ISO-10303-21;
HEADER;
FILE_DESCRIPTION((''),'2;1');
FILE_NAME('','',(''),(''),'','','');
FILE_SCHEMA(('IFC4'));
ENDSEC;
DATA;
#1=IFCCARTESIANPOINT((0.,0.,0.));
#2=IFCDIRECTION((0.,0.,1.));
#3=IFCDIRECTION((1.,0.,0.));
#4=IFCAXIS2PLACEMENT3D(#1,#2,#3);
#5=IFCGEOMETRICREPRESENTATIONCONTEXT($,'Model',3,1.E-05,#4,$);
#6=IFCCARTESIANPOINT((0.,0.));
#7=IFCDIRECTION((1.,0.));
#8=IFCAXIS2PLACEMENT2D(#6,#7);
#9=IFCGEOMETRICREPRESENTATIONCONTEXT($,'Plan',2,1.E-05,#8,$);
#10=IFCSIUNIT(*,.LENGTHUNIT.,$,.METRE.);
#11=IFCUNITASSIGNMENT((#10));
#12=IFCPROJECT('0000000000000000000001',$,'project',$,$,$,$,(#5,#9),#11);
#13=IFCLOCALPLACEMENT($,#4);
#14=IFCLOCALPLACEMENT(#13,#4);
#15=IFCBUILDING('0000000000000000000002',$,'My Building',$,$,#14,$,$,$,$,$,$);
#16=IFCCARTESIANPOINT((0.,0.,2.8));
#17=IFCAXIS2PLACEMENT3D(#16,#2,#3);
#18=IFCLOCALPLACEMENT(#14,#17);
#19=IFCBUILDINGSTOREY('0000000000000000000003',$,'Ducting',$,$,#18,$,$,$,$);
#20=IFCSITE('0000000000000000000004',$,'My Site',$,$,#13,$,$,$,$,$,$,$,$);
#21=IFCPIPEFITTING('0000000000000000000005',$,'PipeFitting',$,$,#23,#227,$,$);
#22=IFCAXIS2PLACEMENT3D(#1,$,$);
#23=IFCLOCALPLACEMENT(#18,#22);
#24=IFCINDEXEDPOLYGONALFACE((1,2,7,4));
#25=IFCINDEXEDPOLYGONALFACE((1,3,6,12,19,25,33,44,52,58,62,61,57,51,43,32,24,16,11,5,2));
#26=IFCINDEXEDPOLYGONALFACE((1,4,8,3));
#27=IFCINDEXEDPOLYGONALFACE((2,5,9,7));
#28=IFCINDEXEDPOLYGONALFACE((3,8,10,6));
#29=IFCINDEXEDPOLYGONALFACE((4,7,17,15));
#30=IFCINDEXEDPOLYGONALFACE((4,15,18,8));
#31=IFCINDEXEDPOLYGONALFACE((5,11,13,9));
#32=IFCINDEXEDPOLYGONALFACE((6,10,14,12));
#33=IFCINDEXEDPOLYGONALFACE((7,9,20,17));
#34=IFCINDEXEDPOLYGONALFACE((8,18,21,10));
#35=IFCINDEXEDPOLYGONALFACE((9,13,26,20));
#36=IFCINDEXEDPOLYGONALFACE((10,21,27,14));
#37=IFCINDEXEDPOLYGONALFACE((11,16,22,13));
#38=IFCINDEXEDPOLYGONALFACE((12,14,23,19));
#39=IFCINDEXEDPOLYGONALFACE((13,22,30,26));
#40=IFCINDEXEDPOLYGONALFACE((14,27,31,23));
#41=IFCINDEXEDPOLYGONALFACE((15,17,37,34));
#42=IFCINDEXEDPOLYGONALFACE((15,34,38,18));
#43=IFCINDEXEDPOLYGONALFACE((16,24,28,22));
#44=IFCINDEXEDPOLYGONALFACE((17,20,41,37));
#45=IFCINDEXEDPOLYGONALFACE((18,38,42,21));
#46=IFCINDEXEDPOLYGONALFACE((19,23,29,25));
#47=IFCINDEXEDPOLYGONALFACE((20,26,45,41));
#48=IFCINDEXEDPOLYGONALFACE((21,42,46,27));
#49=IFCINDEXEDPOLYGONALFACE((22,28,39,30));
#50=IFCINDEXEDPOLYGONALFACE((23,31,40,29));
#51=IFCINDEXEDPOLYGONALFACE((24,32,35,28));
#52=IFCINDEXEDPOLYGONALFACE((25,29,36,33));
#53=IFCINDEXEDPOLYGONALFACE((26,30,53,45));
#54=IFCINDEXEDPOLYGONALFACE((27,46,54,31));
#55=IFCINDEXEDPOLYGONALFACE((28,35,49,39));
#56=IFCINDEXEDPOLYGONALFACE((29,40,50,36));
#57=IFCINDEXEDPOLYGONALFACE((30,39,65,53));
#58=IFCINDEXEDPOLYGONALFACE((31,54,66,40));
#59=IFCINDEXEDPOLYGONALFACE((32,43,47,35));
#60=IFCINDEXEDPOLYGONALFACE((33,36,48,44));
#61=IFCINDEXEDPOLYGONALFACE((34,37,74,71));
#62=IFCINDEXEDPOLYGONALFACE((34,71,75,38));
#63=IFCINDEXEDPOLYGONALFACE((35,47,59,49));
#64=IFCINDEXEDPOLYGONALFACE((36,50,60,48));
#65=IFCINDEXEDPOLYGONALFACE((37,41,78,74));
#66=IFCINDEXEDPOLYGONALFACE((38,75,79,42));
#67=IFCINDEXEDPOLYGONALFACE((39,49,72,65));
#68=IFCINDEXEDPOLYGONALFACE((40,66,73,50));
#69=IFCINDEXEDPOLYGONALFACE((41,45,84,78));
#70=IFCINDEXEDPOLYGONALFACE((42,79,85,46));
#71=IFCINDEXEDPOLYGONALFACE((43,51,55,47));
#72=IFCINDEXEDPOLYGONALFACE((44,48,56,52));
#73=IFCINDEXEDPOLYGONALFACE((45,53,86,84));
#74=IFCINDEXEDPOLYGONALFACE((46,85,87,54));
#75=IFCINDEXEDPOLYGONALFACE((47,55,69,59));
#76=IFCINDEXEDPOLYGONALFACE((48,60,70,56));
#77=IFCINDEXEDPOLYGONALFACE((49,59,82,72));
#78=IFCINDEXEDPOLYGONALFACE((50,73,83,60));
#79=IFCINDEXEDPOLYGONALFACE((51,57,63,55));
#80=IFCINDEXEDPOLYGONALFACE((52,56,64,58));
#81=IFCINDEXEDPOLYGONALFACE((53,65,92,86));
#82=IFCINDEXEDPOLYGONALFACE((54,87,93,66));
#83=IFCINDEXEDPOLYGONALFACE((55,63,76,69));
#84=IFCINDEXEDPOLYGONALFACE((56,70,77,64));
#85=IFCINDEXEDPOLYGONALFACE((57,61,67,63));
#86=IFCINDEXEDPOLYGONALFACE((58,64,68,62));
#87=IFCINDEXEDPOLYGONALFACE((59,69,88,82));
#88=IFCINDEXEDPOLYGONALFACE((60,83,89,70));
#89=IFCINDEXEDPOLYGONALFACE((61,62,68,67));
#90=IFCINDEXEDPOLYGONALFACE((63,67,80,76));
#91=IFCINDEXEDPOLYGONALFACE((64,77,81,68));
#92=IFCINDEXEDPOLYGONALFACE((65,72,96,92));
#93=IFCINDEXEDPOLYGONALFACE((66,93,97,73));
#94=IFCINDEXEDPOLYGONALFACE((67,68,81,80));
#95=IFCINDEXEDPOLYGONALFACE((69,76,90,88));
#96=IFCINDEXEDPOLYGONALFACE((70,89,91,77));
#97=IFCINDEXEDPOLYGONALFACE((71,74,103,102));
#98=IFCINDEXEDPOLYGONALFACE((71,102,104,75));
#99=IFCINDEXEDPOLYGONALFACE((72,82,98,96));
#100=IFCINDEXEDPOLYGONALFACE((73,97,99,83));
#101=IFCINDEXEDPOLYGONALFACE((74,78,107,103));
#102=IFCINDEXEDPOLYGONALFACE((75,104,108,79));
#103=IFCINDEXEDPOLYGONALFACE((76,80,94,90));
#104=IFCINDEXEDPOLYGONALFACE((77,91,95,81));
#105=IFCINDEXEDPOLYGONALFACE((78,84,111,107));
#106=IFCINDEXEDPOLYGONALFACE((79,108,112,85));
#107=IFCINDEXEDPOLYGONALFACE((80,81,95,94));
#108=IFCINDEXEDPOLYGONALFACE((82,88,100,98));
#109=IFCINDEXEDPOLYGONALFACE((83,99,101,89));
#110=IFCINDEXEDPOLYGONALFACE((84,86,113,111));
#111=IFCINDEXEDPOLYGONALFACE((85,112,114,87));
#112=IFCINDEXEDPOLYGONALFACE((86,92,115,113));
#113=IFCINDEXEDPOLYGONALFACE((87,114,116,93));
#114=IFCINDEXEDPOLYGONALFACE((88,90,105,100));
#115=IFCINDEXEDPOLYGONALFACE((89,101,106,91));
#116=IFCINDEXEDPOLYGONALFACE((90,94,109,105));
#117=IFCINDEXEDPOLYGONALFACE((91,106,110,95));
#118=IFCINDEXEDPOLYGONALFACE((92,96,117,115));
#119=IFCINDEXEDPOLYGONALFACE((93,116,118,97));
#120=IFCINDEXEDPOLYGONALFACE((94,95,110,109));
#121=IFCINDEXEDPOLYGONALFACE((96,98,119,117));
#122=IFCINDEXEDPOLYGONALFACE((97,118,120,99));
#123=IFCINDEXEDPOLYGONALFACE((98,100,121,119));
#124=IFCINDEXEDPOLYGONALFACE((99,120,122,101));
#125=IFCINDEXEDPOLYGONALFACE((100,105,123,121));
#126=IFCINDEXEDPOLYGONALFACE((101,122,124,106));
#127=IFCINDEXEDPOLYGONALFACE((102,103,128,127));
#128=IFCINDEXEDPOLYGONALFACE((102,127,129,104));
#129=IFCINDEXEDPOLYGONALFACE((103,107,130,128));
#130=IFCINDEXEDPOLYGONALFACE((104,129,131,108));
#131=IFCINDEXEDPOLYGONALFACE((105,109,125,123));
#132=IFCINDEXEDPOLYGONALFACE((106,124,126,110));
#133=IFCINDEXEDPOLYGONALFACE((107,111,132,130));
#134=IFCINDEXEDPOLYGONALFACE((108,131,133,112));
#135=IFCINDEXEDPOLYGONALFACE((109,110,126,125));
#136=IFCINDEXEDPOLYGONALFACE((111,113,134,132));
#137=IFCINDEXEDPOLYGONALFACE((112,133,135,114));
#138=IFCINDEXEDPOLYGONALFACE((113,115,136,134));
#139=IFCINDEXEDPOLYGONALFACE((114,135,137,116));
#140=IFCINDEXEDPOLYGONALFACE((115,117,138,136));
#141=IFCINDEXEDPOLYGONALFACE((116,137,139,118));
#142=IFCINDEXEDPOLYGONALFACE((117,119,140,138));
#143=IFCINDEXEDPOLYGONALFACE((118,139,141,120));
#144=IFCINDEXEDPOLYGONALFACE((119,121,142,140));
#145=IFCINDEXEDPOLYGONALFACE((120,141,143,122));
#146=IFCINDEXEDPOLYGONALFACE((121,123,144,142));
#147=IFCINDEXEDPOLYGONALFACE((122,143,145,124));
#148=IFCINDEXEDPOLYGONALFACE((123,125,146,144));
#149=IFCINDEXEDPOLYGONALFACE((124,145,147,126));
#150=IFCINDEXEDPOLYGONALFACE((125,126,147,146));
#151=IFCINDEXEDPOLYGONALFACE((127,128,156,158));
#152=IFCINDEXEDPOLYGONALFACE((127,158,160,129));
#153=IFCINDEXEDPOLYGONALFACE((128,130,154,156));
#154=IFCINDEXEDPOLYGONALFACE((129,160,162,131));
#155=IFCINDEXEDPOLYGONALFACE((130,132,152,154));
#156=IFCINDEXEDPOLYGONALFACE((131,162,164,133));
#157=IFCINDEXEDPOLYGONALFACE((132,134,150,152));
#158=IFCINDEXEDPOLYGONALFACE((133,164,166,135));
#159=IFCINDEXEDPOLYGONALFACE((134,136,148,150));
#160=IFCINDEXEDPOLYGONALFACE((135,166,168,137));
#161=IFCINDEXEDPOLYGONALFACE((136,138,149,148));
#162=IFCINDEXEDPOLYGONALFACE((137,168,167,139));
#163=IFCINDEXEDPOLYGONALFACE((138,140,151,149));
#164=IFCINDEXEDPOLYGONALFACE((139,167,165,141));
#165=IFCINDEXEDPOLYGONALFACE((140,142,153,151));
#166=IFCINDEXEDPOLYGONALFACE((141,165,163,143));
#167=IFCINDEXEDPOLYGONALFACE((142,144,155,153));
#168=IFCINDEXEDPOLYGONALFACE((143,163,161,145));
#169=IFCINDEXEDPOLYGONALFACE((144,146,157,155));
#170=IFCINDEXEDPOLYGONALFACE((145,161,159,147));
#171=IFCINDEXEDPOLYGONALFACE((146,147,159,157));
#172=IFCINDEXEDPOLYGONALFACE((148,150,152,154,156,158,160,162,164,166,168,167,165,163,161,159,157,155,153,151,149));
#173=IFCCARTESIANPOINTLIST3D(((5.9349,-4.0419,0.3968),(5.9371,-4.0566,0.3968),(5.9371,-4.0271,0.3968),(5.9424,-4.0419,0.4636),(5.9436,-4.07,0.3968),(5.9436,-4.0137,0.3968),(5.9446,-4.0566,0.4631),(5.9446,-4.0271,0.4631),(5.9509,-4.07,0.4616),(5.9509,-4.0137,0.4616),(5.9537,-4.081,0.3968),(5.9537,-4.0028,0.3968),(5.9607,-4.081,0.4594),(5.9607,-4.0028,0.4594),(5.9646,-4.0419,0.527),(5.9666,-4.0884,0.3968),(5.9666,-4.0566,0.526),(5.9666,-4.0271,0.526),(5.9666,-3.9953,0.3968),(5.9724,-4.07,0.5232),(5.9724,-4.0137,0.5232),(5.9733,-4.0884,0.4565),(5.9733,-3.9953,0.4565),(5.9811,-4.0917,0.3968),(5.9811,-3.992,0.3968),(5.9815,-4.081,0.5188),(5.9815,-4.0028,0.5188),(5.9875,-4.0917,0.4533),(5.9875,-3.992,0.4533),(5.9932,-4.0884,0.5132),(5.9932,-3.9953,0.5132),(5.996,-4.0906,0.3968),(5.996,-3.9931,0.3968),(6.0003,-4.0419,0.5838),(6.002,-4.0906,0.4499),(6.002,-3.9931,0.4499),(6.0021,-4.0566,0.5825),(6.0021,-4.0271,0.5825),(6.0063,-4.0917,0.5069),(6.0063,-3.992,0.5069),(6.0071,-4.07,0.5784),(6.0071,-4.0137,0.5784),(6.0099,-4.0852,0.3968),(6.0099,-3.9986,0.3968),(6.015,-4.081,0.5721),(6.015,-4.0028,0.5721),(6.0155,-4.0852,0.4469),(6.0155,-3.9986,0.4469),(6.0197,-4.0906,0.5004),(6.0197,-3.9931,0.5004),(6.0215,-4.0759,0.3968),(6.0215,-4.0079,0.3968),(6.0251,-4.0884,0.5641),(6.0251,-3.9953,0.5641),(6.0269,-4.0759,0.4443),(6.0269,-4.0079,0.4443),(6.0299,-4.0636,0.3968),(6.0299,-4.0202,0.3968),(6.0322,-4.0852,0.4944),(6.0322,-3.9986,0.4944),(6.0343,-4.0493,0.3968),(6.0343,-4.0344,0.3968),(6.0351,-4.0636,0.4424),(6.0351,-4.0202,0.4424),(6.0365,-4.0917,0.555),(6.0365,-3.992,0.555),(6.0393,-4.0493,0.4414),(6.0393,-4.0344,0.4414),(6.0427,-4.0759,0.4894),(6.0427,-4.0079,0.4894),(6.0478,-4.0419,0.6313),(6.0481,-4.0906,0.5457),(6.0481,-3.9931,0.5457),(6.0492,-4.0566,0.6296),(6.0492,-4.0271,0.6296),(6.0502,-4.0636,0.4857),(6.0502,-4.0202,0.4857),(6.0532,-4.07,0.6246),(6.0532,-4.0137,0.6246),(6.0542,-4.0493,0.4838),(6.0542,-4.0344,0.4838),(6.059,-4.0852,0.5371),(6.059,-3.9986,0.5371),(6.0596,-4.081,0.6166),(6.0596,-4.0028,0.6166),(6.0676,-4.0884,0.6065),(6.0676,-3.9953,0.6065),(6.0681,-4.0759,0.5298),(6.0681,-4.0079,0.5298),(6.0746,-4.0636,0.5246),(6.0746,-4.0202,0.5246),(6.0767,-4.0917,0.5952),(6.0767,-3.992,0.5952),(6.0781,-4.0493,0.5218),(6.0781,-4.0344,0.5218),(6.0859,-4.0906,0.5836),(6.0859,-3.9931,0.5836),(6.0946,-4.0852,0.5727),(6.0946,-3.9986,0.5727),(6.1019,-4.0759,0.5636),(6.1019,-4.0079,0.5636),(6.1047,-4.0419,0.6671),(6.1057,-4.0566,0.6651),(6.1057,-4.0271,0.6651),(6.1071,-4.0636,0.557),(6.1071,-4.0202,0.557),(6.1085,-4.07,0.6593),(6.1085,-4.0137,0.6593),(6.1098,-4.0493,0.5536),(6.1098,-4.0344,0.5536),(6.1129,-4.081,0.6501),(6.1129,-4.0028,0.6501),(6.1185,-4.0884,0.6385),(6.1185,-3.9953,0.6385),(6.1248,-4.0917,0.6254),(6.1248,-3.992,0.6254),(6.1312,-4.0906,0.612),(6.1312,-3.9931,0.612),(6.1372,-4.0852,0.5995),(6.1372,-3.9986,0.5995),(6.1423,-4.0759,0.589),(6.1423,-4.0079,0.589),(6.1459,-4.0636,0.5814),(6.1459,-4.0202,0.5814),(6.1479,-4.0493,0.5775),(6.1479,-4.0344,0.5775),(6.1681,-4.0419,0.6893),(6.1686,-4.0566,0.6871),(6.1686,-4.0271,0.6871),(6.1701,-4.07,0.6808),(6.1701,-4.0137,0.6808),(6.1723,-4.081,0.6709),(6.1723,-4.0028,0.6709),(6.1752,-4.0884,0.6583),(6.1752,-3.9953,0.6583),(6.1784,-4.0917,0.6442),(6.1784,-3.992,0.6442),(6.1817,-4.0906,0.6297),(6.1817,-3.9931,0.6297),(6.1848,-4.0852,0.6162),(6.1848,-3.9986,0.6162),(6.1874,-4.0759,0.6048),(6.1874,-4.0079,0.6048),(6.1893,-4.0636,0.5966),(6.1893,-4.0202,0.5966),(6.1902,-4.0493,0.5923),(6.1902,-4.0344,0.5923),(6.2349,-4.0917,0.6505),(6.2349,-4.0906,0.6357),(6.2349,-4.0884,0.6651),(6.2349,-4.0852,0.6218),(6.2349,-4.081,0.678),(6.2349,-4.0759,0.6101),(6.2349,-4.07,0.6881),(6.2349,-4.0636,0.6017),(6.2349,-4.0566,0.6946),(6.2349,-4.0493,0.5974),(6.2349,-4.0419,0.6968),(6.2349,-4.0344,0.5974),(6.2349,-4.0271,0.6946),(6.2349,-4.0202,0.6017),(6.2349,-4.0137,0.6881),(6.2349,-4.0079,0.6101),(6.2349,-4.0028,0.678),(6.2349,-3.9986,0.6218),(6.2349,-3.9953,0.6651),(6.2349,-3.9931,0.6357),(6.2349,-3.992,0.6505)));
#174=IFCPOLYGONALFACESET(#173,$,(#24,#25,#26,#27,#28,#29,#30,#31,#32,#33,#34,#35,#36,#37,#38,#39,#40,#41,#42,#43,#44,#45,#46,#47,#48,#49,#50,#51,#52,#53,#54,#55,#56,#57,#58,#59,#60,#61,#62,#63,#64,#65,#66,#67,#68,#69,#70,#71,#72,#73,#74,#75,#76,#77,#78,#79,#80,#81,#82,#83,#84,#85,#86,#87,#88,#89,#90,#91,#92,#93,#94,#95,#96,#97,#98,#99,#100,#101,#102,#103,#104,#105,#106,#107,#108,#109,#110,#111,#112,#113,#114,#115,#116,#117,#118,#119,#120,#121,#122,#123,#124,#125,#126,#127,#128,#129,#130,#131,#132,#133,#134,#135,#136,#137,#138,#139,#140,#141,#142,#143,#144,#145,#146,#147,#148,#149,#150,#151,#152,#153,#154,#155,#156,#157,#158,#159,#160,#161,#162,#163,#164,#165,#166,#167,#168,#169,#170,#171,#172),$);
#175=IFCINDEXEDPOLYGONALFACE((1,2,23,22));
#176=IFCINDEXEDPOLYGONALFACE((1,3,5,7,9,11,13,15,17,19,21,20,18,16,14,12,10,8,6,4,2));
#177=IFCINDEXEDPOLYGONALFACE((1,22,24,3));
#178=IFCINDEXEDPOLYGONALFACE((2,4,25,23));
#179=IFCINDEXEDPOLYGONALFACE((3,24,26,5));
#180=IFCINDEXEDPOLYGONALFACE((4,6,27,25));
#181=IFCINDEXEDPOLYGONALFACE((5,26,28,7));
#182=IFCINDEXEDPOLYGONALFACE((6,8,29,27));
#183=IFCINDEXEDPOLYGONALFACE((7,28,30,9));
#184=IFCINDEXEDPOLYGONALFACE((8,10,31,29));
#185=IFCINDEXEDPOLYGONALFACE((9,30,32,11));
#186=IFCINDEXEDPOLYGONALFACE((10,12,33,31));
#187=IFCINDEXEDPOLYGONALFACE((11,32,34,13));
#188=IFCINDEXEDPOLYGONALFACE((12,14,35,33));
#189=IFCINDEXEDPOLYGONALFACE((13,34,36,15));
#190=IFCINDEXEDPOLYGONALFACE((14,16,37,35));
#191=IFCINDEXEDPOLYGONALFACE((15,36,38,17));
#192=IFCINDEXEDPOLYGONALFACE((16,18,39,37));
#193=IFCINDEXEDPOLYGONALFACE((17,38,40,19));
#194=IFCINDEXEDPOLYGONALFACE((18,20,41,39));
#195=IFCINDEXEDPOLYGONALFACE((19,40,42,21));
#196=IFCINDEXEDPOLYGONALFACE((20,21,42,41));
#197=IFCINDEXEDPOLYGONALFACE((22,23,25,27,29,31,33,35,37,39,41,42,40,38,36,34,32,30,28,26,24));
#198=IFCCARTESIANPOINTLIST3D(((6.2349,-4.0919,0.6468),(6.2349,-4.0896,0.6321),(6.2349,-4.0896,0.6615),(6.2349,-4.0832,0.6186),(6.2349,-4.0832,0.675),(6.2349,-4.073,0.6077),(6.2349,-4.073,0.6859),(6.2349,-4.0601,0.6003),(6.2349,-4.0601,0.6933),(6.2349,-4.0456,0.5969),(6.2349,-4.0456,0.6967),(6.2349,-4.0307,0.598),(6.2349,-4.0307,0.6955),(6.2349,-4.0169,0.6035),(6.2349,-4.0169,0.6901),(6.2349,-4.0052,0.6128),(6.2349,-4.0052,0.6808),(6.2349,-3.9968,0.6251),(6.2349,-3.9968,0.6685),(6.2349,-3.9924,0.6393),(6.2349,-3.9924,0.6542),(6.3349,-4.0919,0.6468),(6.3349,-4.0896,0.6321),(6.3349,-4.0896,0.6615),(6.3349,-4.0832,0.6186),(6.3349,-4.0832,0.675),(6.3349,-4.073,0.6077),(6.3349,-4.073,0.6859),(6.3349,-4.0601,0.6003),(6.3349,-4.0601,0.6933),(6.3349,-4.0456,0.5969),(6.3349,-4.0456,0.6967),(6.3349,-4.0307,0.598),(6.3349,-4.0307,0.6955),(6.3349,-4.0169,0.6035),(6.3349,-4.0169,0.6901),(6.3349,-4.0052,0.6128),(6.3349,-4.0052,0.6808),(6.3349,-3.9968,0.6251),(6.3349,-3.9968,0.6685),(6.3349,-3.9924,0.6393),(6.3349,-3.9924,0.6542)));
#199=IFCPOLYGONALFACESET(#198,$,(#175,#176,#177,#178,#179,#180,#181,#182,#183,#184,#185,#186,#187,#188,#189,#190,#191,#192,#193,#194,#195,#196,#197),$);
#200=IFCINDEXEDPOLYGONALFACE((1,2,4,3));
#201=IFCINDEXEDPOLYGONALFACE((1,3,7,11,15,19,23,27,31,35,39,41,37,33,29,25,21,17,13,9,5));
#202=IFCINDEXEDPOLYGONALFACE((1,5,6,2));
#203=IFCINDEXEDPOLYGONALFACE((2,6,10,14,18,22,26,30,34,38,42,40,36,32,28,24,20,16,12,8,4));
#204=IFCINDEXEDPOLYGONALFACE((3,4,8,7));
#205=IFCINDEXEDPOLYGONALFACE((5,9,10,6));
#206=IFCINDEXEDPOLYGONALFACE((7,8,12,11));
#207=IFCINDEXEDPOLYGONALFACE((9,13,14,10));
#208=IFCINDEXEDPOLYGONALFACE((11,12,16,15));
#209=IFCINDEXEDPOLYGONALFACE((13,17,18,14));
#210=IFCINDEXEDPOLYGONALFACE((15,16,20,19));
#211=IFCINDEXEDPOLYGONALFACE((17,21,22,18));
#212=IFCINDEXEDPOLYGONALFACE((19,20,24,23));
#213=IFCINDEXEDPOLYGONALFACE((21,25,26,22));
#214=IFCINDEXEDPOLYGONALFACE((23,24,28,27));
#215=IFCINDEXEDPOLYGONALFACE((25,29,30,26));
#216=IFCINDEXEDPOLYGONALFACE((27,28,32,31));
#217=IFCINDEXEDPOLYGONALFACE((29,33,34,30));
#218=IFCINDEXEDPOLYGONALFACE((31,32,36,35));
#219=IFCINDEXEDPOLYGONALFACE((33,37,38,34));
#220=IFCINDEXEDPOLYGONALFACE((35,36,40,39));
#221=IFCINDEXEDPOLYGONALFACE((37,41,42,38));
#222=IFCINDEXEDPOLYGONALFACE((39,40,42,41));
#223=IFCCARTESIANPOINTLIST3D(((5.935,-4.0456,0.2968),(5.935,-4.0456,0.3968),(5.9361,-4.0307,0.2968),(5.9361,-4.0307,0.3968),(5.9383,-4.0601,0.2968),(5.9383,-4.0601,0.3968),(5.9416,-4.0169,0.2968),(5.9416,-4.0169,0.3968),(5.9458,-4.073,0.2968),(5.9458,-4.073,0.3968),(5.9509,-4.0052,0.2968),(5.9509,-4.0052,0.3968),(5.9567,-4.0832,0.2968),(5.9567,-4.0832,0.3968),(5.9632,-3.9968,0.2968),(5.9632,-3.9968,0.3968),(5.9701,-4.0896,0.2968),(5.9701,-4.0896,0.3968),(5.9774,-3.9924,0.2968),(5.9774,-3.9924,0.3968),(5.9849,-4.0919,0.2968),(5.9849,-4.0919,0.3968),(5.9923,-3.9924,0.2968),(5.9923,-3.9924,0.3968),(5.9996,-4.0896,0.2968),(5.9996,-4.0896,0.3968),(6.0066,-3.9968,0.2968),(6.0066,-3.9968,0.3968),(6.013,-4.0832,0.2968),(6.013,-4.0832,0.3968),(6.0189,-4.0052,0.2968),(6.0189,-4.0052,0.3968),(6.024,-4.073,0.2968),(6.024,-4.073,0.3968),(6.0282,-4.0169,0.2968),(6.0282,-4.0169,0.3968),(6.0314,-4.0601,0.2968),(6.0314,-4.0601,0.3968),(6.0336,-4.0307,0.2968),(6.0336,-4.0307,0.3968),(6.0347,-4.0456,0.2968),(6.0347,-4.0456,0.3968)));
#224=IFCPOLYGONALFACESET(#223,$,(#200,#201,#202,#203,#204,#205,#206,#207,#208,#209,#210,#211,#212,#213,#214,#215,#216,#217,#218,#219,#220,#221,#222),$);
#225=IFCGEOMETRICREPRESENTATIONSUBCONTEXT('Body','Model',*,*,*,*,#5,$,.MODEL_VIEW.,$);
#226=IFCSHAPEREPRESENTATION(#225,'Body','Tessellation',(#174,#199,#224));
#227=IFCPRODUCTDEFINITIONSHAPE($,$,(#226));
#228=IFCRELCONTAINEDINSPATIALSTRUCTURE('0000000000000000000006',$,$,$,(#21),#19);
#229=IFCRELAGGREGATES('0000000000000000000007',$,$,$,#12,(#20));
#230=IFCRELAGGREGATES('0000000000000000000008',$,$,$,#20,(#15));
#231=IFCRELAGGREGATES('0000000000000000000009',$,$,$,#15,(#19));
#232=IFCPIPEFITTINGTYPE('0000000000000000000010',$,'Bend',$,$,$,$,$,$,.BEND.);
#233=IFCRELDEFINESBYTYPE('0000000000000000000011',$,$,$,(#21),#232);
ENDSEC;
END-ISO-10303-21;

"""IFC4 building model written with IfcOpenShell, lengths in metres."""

from ifc_helpers import new_model, entity, si_unit, frame, origin_with_axes, origin_2d_with_axis, place, context, subcontext, project, spatial, circle, extrude, source, transform, mapped, type_object, type_shapes, element, save


model = new_model("IFC4")

# Units and contexts
model_context = context("Model", 3, precision=1e-05, world=origin_with_axes())
plan_context = context("Plan", 2, precision=1e-05, world=origin_2d_with_axis())
body_context = subcontext(model_context, "Body", "Model", "MODEL_VIEW")
ifc_project = project(units=[si_unit("LENGTHUNIT", "METRE")], contexts=[model_context, plan_context])

# Site, building, storey
site_placement = place(None, origin_with_axes())
site = spatial("IfcSite", under=ifc_project, at=site_placement, Name="My Site")
building_placement = place(site_placement, origin_with_axes())
building = spatial("IfcBuilding", under=site, at=building_placement, Name="My Building")
storey_placement = place(building_placement, frame((0.0, 0.0, 2.8), z_axis=(0.0, 0.0, 1.0), x_axis=(1.0, 0.0, 0.0)))
storey = spatial("IfcBuildingStorey", under=building, at=storey_placement, Name="Ducting")

# Pipe fitting
pipe_fitting_type = type_object("IfcPipeFittingType", Name="Bend", PredefinedType="BEND")
shared_shape_1 = source(origin_with_axes(), body_context, "Body", "SolidModel", [
    entity("IfcSweptDiskSolid", entity("IfcIndexedPolyCurve", entity("IfcCartesianPointList3D", [[0.0, 0.0, 0.1], [0.0, -0.0732, 0.2768], [0.0, -0.25, 0.35]]), [entity("IfcArcIndex", [1, 2, 3])]), 0.05),
    extrude(circle(Radius=0.05), origin_with_axes(), (0.0, 0.0, 1.0), 0.1),
    extrude(circle(Radius=0.05), frame((0.0, -0.25, 0.35), z_axis=(0.0, -1.0, 0.0), x_axis=(1.0, 0.0, 0.0)), (0.0, 0.0, 1.0), 0.1),
])
type_shapes(pipe_fitting_type, [shared_shape_1])
for number, where, z_axis, x_axis, name in (
    (1, (6.3349, -4.0419, 0.6468), (-1.0, 0.0, 0.0), (0.0, -1.0, 0.0), "PipeFitting"),
):
    element("IfcPipeFitting", number, at=place(storey_placement, frame(where, z_axis=z_axis, x_axis=x_axis)), inside=storey, type_object=pipe_fitting_type, Name=name, context=body_context, shape_type="MappedRepresentation", body=[
        mapped(shared_shape_1, transform((0.0, 0.0, 0.0), x_axis=(1.0, 0.0, 0.0), y_axis=(0.0, 1.0, 0.0), z_axis=(0.0, 0.0, 1.0), scale=1.0)),
    ])

save(model, "model.ifc")
